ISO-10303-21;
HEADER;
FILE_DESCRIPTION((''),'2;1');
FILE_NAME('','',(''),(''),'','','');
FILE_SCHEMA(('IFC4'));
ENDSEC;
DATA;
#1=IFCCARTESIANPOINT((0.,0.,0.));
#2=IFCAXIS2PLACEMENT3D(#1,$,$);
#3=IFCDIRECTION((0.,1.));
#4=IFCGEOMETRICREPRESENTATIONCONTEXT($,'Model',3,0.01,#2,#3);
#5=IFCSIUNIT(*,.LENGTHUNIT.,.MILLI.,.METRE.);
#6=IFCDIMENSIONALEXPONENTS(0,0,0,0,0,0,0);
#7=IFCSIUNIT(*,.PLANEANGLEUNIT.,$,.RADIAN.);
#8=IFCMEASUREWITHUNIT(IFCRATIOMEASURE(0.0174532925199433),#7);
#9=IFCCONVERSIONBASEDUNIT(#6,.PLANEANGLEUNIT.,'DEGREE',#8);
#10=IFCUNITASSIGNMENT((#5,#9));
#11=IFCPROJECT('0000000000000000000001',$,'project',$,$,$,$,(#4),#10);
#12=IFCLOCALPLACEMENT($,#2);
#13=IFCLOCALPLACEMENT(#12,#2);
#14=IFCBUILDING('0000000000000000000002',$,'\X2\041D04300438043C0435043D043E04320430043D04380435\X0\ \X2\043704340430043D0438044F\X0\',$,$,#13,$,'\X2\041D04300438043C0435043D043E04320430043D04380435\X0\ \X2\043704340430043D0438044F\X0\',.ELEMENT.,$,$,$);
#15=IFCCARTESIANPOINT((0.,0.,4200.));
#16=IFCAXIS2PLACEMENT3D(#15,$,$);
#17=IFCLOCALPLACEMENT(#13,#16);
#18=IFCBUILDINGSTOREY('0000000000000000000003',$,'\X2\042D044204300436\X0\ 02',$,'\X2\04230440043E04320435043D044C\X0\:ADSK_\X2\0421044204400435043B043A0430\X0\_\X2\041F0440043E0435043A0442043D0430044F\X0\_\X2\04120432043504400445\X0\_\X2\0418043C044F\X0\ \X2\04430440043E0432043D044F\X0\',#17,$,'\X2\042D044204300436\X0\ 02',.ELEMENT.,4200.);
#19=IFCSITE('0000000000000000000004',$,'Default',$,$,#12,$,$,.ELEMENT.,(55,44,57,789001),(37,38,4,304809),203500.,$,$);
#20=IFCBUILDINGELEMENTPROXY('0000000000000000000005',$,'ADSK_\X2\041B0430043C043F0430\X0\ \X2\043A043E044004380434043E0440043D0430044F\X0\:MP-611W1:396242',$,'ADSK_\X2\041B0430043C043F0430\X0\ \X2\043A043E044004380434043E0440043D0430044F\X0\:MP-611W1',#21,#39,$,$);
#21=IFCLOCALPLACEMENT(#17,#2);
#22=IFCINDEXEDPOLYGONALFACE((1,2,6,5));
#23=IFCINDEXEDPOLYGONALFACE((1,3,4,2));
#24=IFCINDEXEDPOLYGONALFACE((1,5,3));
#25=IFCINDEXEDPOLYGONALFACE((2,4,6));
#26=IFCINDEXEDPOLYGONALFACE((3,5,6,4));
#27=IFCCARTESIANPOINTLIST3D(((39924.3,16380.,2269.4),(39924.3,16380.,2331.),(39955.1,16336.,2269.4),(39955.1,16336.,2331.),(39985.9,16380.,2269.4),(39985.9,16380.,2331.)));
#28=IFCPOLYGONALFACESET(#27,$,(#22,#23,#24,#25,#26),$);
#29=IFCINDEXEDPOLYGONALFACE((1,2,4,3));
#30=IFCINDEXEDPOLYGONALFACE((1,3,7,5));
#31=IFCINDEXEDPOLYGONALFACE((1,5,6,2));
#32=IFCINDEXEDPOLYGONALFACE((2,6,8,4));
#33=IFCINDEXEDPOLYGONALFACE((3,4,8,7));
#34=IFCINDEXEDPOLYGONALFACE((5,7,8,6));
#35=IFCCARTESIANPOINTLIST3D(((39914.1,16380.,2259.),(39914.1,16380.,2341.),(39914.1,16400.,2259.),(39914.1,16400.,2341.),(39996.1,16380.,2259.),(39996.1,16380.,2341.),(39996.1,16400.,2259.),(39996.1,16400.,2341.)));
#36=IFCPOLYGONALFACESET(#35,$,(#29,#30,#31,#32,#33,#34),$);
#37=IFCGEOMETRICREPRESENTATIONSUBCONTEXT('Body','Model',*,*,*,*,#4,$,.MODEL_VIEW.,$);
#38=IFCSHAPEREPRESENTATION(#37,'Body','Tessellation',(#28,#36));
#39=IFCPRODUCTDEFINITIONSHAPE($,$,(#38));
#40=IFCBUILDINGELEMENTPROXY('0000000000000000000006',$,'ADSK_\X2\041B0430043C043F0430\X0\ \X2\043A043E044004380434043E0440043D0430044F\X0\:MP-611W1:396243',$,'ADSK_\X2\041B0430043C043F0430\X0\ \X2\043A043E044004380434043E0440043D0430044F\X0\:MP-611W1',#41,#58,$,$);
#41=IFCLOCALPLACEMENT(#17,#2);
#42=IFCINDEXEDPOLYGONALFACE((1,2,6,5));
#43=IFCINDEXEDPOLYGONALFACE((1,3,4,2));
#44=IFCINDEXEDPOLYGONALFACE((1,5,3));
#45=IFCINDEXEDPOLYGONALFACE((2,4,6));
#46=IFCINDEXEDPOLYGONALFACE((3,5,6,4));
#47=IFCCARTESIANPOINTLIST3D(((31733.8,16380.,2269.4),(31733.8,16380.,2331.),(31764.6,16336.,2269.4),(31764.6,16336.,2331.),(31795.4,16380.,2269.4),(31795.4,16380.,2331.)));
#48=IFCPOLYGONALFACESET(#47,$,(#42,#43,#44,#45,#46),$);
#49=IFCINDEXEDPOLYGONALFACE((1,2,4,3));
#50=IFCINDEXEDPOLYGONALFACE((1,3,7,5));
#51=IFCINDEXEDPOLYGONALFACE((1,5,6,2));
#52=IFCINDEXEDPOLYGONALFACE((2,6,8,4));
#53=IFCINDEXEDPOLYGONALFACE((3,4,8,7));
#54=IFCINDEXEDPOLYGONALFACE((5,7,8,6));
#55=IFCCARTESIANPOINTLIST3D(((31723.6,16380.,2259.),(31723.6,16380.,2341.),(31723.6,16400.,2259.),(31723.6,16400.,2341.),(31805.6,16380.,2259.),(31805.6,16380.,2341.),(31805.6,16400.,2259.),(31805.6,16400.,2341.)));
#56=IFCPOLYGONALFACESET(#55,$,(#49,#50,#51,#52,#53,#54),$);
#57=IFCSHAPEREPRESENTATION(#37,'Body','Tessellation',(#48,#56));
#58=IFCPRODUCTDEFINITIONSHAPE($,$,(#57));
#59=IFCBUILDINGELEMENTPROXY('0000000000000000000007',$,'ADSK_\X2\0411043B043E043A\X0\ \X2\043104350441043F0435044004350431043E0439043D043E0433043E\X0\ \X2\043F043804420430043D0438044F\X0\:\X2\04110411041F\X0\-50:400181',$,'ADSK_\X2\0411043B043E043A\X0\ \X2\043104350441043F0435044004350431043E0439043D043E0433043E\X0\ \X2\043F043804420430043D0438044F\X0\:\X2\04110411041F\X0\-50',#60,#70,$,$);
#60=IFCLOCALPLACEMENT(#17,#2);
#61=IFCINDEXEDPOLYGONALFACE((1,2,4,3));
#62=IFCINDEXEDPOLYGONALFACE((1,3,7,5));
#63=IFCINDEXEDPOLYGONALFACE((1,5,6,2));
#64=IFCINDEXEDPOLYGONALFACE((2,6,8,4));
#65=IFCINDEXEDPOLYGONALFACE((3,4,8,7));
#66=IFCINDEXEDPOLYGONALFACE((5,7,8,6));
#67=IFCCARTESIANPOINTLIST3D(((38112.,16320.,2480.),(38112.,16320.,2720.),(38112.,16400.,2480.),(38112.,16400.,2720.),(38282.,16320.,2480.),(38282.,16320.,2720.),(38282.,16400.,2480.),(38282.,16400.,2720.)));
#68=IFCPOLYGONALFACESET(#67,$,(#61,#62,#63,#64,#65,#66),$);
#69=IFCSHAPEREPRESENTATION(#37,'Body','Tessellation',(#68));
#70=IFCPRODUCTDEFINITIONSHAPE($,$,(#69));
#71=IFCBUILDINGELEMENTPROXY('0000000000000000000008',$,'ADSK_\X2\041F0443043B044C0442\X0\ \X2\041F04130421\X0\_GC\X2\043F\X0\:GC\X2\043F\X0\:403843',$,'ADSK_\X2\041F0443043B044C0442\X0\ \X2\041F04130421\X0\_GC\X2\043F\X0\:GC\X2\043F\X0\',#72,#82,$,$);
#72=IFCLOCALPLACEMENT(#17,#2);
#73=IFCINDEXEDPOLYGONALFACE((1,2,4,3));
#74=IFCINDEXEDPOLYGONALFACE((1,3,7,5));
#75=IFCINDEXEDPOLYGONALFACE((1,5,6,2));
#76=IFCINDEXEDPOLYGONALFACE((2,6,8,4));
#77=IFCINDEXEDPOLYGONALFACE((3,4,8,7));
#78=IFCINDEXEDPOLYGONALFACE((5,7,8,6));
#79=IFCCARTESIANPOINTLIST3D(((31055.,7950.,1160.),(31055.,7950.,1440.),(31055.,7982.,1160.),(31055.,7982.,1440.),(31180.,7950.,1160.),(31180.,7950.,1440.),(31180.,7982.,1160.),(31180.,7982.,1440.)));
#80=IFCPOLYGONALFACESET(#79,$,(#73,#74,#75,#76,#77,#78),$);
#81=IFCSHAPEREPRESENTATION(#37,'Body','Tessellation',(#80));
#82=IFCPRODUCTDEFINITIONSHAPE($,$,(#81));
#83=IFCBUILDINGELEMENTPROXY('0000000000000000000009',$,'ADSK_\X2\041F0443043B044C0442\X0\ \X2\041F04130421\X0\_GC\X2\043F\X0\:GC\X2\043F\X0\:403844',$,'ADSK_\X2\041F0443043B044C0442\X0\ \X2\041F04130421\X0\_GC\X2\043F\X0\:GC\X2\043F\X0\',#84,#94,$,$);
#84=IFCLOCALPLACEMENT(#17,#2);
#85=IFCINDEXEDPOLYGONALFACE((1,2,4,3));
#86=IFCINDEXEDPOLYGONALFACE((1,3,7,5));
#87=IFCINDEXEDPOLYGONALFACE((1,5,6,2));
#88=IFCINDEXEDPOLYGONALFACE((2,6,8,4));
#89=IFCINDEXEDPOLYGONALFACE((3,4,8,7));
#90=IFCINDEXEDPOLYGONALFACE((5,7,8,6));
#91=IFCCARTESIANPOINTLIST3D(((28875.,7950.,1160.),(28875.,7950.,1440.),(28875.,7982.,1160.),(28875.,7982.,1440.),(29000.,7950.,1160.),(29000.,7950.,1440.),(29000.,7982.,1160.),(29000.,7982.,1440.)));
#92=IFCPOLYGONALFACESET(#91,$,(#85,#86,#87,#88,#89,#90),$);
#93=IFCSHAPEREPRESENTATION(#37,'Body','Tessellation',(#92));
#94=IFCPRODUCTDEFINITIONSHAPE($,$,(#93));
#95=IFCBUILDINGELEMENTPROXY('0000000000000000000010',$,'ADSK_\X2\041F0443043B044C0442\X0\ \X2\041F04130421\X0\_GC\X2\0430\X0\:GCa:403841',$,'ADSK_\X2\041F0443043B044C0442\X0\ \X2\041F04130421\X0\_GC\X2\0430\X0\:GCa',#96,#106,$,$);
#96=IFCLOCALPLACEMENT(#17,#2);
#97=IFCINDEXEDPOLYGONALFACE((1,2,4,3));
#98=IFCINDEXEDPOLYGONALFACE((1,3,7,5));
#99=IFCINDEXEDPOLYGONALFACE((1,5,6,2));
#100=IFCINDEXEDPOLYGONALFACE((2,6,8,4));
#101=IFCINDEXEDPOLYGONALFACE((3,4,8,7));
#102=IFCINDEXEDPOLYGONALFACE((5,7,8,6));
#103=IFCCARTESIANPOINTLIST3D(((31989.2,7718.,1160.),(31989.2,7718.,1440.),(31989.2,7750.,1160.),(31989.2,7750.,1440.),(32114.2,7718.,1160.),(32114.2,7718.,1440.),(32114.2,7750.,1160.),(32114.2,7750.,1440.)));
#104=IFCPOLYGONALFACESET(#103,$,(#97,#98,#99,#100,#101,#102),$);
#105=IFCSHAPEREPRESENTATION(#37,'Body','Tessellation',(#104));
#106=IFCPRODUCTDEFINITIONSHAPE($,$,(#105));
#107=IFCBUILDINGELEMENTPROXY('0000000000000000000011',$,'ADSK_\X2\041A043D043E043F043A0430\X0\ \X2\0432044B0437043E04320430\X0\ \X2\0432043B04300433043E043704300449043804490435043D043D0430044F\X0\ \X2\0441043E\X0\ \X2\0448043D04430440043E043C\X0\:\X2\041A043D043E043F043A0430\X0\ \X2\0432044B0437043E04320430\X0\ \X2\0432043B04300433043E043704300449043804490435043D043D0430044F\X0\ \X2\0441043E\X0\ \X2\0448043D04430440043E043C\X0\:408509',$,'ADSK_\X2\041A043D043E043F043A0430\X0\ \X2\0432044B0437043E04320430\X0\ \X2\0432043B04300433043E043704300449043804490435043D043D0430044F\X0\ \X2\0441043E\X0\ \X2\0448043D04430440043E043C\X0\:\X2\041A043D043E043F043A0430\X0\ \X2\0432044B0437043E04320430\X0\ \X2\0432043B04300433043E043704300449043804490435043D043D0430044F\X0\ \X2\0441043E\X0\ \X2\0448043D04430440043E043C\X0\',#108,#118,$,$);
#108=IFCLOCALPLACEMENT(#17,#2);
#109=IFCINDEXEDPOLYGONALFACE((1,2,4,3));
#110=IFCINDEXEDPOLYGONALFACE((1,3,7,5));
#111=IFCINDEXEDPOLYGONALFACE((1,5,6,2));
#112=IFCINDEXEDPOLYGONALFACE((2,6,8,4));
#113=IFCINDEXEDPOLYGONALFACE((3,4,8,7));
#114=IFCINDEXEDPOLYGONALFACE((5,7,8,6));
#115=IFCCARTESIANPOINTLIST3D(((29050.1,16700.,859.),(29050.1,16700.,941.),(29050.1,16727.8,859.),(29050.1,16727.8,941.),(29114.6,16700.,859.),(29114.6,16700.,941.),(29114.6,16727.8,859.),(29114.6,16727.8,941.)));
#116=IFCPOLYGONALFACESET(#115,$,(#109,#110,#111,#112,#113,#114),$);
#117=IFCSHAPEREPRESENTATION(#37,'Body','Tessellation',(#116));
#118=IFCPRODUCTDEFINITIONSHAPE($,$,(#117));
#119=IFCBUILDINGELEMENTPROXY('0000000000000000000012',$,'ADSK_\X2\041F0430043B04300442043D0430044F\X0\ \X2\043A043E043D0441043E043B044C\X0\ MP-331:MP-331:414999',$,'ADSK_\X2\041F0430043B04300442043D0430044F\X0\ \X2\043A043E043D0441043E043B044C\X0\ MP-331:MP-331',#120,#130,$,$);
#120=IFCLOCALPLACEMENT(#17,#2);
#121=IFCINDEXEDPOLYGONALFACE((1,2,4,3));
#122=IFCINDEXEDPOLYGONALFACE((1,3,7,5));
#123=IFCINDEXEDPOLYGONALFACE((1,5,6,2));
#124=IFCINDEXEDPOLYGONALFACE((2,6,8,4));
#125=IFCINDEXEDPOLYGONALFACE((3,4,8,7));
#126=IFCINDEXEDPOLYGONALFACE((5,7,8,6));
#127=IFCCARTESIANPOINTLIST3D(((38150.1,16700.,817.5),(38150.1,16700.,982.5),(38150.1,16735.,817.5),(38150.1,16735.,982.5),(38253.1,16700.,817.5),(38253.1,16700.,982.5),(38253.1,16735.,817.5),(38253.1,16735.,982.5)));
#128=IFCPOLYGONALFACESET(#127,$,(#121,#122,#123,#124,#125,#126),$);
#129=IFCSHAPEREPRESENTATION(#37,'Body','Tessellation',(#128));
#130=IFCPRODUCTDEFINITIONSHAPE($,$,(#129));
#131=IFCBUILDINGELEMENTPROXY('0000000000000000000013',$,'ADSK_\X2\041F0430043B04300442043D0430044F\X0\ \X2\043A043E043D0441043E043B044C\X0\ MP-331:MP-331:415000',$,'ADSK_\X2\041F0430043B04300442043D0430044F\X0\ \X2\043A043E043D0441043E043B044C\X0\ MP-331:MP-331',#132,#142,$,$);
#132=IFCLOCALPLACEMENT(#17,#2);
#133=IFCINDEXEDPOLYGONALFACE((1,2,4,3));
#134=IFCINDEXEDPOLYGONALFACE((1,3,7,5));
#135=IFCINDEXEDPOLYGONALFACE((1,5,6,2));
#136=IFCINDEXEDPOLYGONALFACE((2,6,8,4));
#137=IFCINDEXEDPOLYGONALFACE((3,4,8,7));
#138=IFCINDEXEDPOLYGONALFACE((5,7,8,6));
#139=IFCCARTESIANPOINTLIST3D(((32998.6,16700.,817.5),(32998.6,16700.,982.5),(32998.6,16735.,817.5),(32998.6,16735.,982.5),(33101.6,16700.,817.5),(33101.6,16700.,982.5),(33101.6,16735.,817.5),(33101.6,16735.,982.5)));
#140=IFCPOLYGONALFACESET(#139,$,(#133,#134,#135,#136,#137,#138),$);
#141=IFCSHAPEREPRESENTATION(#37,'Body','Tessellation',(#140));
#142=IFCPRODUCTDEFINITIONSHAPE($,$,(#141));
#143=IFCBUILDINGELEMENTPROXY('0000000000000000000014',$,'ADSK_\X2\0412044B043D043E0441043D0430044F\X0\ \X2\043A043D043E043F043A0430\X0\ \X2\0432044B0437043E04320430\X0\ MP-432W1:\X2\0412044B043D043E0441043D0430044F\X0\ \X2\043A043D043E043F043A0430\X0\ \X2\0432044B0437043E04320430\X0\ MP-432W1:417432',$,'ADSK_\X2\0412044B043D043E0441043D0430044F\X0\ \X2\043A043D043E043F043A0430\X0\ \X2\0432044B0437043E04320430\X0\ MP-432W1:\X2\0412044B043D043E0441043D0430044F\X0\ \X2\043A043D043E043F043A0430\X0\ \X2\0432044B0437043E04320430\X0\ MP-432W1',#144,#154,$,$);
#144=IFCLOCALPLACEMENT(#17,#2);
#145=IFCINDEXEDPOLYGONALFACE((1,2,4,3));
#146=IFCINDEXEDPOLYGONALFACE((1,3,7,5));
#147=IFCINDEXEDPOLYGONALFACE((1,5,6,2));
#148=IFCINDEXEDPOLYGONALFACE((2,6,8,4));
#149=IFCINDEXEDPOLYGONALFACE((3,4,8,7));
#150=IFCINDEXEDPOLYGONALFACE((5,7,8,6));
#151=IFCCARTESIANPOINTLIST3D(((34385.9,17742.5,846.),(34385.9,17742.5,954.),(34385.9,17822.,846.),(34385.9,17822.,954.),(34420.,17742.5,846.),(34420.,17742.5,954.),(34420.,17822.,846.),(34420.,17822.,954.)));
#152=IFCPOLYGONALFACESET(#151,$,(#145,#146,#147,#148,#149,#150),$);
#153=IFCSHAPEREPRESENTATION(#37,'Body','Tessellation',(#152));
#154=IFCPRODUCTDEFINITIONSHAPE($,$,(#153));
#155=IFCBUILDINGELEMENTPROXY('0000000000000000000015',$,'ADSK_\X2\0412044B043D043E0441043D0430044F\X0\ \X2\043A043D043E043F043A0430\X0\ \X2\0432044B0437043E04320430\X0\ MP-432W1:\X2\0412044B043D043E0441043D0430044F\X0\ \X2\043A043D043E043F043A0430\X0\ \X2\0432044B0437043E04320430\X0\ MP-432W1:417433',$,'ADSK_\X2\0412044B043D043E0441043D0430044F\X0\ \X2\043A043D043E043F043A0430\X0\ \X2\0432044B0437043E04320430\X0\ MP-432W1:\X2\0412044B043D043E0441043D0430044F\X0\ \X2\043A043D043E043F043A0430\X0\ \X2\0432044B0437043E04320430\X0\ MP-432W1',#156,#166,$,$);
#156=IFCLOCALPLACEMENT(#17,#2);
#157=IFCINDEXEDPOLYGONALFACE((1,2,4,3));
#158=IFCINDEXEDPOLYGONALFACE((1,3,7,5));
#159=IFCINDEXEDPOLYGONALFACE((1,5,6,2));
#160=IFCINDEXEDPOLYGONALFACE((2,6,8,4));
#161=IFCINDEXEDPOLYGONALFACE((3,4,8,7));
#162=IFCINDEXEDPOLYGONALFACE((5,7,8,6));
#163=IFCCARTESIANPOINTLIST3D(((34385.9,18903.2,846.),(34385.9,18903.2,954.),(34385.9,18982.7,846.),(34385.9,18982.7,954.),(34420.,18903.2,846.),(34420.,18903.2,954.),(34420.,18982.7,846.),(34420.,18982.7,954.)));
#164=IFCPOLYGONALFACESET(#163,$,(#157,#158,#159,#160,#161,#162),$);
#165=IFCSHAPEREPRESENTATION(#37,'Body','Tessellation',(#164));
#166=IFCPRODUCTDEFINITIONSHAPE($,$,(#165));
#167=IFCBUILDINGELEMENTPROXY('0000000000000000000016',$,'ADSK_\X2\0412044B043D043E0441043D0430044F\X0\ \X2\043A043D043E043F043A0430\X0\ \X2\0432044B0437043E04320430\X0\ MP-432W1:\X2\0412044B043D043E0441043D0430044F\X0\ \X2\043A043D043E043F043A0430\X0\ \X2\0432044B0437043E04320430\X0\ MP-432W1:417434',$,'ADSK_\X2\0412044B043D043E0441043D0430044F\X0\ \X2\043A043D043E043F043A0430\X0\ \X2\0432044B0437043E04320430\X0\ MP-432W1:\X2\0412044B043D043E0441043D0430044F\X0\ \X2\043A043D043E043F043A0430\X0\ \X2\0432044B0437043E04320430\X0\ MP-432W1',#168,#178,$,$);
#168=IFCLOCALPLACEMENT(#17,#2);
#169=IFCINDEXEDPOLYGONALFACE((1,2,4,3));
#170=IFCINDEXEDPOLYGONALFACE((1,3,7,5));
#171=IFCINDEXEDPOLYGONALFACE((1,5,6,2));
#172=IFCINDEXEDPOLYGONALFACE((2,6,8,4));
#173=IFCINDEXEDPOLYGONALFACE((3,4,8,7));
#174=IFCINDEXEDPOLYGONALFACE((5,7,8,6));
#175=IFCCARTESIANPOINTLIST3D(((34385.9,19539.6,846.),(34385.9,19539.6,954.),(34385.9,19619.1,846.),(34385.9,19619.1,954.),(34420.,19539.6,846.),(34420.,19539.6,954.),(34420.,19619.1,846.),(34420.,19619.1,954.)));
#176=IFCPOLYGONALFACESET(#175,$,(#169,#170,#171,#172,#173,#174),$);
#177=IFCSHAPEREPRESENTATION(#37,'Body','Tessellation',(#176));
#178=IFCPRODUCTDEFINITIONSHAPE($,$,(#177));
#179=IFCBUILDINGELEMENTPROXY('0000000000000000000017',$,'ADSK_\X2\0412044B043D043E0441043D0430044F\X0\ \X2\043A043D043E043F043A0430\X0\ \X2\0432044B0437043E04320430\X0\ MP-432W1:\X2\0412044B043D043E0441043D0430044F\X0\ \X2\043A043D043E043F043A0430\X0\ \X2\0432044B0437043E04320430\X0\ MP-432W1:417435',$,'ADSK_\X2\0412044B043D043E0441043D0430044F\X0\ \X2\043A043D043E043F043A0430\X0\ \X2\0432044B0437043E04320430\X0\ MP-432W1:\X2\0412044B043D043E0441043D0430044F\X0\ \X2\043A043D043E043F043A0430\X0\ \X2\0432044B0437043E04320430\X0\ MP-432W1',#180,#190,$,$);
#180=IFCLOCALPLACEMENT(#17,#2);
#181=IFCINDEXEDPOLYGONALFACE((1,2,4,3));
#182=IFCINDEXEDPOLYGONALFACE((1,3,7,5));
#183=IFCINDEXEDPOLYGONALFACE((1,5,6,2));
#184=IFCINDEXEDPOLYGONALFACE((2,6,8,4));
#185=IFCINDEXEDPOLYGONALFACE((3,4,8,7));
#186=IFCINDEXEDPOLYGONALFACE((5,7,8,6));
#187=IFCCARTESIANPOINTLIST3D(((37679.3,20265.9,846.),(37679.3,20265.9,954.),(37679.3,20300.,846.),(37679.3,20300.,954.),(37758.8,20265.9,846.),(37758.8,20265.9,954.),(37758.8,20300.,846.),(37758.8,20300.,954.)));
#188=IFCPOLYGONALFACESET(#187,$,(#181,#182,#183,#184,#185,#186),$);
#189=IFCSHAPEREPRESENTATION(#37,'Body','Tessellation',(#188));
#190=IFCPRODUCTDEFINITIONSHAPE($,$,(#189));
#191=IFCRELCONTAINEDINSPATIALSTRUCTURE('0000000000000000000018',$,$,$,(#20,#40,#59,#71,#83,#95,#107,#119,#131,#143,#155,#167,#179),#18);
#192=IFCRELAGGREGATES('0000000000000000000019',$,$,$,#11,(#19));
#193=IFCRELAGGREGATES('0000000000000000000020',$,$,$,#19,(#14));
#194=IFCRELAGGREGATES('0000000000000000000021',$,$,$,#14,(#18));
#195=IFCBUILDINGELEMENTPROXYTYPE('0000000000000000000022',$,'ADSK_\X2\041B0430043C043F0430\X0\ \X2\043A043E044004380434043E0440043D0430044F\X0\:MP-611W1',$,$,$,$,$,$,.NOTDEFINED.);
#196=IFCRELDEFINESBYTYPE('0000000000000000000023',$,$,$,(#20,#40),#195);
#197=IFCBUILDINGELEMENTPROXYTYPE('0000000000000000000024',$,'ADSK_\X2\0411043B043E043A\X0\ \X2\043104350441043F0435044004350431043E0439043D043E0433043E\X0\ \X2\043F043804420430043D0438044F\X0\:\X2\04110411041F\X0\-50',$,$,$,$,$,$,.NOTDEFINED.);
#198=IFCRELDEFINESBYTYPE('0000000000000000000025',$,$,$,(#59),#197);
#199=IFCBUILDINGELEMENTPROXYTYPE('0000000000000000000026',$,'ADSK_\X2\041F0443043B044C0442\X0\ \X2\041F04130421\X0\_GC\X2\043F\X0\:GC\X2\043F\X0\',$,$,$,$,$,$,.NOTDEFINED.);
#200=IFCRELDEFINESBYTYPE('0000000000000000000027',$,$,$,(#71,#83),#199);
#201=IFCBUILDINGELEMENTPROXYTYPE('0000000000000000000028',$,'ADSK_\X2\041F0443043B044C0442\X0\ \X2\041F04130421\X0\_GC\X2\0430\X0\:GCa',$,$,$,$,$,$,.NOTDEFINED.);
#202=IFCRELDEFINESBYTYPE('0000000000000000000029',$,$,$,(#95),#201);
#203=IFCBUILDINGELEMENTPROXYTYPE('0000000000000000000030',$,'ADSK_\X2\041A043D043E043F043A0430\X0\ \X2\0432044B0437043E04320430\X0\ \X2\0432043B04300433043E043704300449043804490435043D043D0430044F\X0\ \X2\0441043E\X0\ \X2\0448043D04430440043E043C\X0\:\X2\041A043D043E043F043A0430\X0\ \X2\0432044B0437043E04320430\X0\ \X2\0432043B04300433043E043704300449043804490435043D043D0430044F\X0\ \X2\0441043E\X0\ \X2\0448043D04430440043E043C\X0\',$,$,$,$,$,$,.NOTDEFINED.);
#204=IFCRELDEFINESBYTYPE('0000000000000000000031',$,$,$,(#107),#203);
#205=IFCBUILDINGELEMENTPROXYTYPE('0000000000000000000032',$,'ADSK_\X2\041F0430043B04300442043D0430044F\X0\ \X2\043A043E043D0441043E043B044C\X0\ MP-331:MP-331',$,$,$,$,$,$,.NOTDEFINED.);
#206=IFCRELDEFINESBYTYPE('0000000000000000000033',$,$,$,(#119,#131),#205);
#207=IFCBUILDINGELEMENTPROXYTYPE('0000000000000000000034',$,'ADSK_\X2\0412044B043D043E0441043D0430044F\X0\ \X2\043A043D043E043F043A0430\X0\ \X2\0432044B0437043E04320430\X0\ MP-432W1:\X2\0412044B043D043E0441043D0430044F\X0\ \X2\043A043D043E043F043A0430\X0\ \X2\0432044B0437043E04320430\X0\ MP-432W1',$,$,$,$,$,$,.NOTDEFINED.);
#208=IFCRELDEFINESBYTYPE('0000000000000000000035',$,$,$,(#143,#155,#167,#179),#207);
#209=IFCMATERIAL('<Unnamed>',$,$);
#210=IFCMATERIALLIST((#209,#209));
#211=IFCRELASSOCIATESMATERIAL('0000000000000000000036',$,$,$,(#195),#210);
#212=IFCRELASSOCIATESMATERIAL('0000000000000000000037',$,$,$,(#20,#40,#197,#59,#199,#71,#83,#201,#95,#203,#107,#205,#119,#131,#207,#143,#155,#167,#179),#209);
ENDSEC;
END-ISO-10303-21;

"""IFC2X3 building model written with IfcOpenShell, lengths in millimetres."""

from ifc_helpers import new_model, entity, si_unit, converted_unit, direction, frame, origin, origin_2d_with_axis, place, context, subcontext, project, spatial, polyline, rectangle, outline, extrude, source, transform, mapped, material, material_list, type_object, type_shapes, element, save


model = new_model("IFC2X3")

# Units and contexts
model_context = context("Model", 3, precision=0.01, world=origin(), true_north=direction((0.0, 1.0)))
body_context = subcontext(model_context, "Body", "Model", "MODEL_VIEW")
ifc_project = project(units=[si_unit("LENGTHUNIT", "METRE", prefix="MILLI"), converted_unit("PLANEANGLEUNIT", "DEGREE", entity("IfcRatioMeasure", 0.0174532925199433), si_unit("PLANEANGLEUNIT", "RADIAN"), dimensions=[0, 0, 0, 0, 0, 0, 0])], contexts=[model_context])

# Site, building, storey
site_placement = place(None, origin())
site = spatial("IfcSite", under=ifc_project, at=site_placement, Name="Default", CompositionType="ELEMENT", RefLatitude=(55, 44, 57, 789001), RefLongitude=(37, 38, 4, 304809), RefElevation=203500.0)
building_placement = place(site_placement, origin())
building = spatial("IfcBuilding", under=site, at=building_placement, Name="Наименование здания", LongName="Наименование здания", CompositionType="ELEMENT")
storey_placement = place(building_placement, frame((0.0, 0.0, 4200.0)))
storey = spatial("IfcBuildingStorey", under=building, at=storey_placement, Name="Этаж 02", ObjectType="Уровень:ADSK_Стрелка_Проектная_Вверх_Имя уровня", LongName="Этаж 02", CompositionType="ELEMENT", Elevation=4200.0)

# Building element proxies
ifc_material_1 = material(Name="<Unnamed>")
ifc_material_list_1 = material_list([ifc_material_1, ifc_material_1])
building_element_proxy_type_1 = type_object("IfcBuildingElementProxyType", Name="ADSK_Лампа коридорная:MP-611W1", PredefinedType="NOTDEFINED", material=ifc_material_list_1)
shared_shape_1 = source(origin(), body_context, "Body", "SweptSolid", [
    extrude(outline(polyline([(-30.8, -14.7), (30.8, -14.7), (0.0, 29.3), (-30.8, -14.7)])), frame((0.0, -2.7, -30.6), z_axis=(0.0, 0.0, 1.0), x_axis=(-1.0, 0.0, 0.0)), (0.0, 0.0, 1.0), 61.6),
    extrude(rectangle(XDim=82.0, YDim=20.0, at=origin_2d_with_axis()), frame((0.0, 22.0, -41.0), z_axis=(0.0, 0.0, 1.0), x_axis=(-1.0, 0.0, 0.0)), (0.0, 0.0, 1.0), 82.0),
])
type_shapes(building_element_proxy_type_1, [shared_shape_1])
for number, where, name in (
    (1, (39955.1, 16368.0, 2300.0), "ADSK_Лампа коридорная:MP-611W1:396242"),
    (2, (31764.6, 16368.0, 2300.0), "ADSK_Лампа коридорная:MP-611W1:396243"),
):
    element("IfcBuildingElementProxy", number, at=place(storey_placement, frame(where)), inside=storey, type_object=building_element_proxy_type_1, material=ifc_material_1, Name=name, ObjectType="ADSK_Лампа коридорная:MP-611W1", context=body_context, shape_type="MappedRepresentation", body=[
        mapped(shared_shape_1, transform((0.0, 0.0, 0.0), scale=1.0)),
    ])
building_element_proxy_type_2 = type_object("IfcBuildingElementProxyType", Name="ADSK_Блок бесперебойного питания:ББП-50", PredefinedType="NOTDEFINED", material=ifc_material_1)
shared_shape_2 = source(origin(), body_context, "Body", "SweptSolid", [
    extrude(rectangle(XDim=170.0, YDim=80.0, at=origin_2d_with_axis()), frame((0.0, -8.0, -120.0), z_axis=(0.0, 0.0, 1.0), x_axis=(-1.0, 0.0, 0.0)), (0.0, 0.0, 1.0), 240.0),
])
type_shapes(building_element_proxy_type_2, [shared_shape_2])
proxy_1_placement = place(storey_placement, frame((38197.0, 16368.0, 2600.0)))
element("IfcBuildingElementProxy", 3, at=proxy_1_placement, inside=storey, type_object=building_element_proxy_type_2, material=ifc_material_1, Name="ADSK_Блок бесперебойного питания:ББП-50:400181", ObjectType="ADSK_Блок бесперебойного питания:ББП-50", context=body_context, shape_type="MappedRepresentation", body=[
    mapped(shared_shape_2, transform((0.0, 0.0, 0.0), scale=1.0)),
])
building_element_proxy_type_3 = type_object("IfcBuildingElementProxyType", Name="ADSK_Пульт ПГС_GCп:GCп", PredefinedType="NOTDEFINED", material=ifc_material_1)
shared_shape_3 = source(origin(), body_context, "Body", "SweptSolid", [
    extrude(rectangle(XDim=125.0, YDim=32.0, at=origin_2d_with_axis()), frame((0.0, 16.0, -140.0), z_axis=(0.0, 0.0, 1.0), x_axis=(-1.0, 0.0, 0.0)), (0.0, 0.0, 1.0), 280.0),
])
type_shapes(building_element_proxy_type_3, [shared_shape_3])
for number, where, z_axis, x_axis, name in (
    (4, (31117.5, 7982.0, 1300.0), (0.0, 0.0, 1.0), (-1.0, 0.0, 0.0), "ADSK_Пульт ПГС_GCп:GCп:403843"),
    (5, (28937.5, 7982.0, 1300.0), (0.0, 0.0, 1.0), (-1.0, 0.0, 0.0), "ADSK_Пульт ПГС_GCп:GCп:403844"),
):
    element("IfcBuildingElementProxy", number, at=place(storey_placement, frame(where, z_axis=z_axis, x_axis=x_axis)), inside=storey, type_object=building_element_proxy_type_3, material=ifc_material_1, Name=name, ObjectType="ADSK_Пульт ПГС_GCп:GCп", context=body_context, shape_type="MappedRepresentation", body=[
        mapped(shared_shape_3, transform((0.0, 0.0, 0.0), scale=1.0)),
    ])
building_element_proxy_type_4 = type_object("IfcBuildingElementProxyType", Name="ADSK_Пульт ПГС_GCа:GCa", PredefinedType="NOTDEFINED", material=ifc_material_1)
shared_shape_4 = source(origin(), body_context, "Body", "SweptSolid", [
    extrude(rectangle(XDim=125.0, YDim=32.0, at=origin_2d_with_axis()), frame((0.0, 16.0, -140.0), z_axis=(0.0, 0.0, 1.0), x_axis=(-1.0, 0.0, 0.0)), (0.0, 0.0, 1.0), 280.0),
])
type_shapes(building_element_proxy_type_4, [shared_shape_4])
proxy_2_placement = place(storey_placement, frame((32051.7, 7718.0, 1300.0)))
element("IfcBuildingElementProxy", 6, at=proxy_2_placement, inside=storey, type_object=building_element_proxy_type_4, material=ifc_material_1, Name="ADSK_Пульт ПГС_GCа:GCa:403841", ObjectType="ADSK_Пульт ПГС_GCа:GCa", context=body_context, shape_type="MappedRepresentation", body=[
    mapped(shared_shape_4, transform((0.0, 0.0, 0.0), scale=1.0)),
])
building_element_proxy_type_5 = type_object("IfcBuildingElementProxyType", Name="ADSK_Кнопка вызова влагозащищенная со шнуром:Кнопка вызова влагозащищенная со шнуром", PredefinedType="NOTDEFINED", material=ifc_material_1)
shared_shape_5 = source(origin(), body_context, "Body", "SweptSolid", [
    extrude(rectangle(XDim=64.5, YDim=27.8, at=origin_2d_with_axis()), frame((32.2, 13.9, 0.0), z_axis=(0.0, 0.0, 1.0), x_axis=(-1.0, 0.0, 0.0)), (0.0, 0.0, 1.0), 82.0),
])
type_shapes(building_element_proxy_type_5, [shared_shape_5])
proxy_3_placement = place(storey_placement, frame((29114.6, 16727.8, 859.0), z_axis=(0.0, 0.0, 1.0), x_axis=(-1.0, 0.0, 0.0)))
element("IfcBuildingElementProxy", 7, at=proxy_3_placement, inside=storey, type_object=building_element_proxy_type_5, material=ifc_material_1, Name="ADSK_Кнопка вызова влагозащищенная со шнуром:Кнопка вызова влагозащищенная со шнуром:408509", ObjectType="ADSK_Кнопка вызова влагозащищенная со шнуром:Кнопка вызова влагозащищенная со шнуром", context=body_context, shape_type="MappedRepresentation", body=[
    mapped(shared_shape_5, transform((0.0, 0.0, 0.0), scale=1.0)),
])
building_element_proxy_type_6 = type_object("IfcBuildingElementProxyType", Name="ADSK_Палатная консоль MP-331:MP-331", PredefinedType="NOTDEFINED", material=ifc_material_1)
shared_shape_6 = source(origin(), body_context, "Body", "SweptSolid", [
    extrude(rectangle(XDim=103.0, YDim=35.0, at=origin_2d_with_axis()), frame((0.0, 14.5, -82.5), z_axis=(0.0, 0.0, 1.0), x_axis=(-1.0, 0.0, 0.0)), (0.0, 0.0, 1.0), 165.0),
])
type_shapes(building_element_proxy_type_6, [shared_shape_6])
for number, where, z_axis, x_axis, name in (
    (8, (38201.6, 16732.0, 900.0), (0.0, 0.0, 1.0), (-1.0, 0.0, 0.0), "ADSK_Палатная консоль MP-331:MP-331:414999"),
    (9, (33050.1, 16732.0, 900.0), (0.0, 0.0, 1.0), (-1.0, 0.0, 0.0), "ADSK_Палатная консоль MP-331:MP-331:415000"),
):
    element("IfcBuildingElementProxy", number, at=place(storey_placement, frame(where, z_axis=z_axis, x_axis=x_axis)), inside=storey, type_object=building_element_proxy_type_6, material=ifc_material_1, Name=name, ObjectType="ADSK_Палатная консоль MP-331:MP-331", context=body_context, shape_type="MappedRepresentation", body=[
        mapped(shared_shape_6, transform((0.0, 0.0, 0.0), scale=1.0)),
    ])
building_element_proxy_type_7 = type_object("IfcBuildingElementProxyType", Name="ADSK_Выносная кнопка вызова MP-432W1:Выносная кнопка вызова MP-432W1", PredefinedType="NOTDEFINED", material=ifc_material_1)
shared_shape_7 = source(origin(), body_context, "Body", "SweptSolid", [
    extrude(rectangle(XDim=79.5, YDim=34.1, at=origin_2d_with_axis()), frame((0.0, 15.0, -54.0), z_axis=(0.0, 0.0, 1.0), x_axis=(-1.0, 0.0, 0.0)), (0.0, 0.0, 1.0), 108.0),
])
type_shapes(building_element_proxy_type_7, [shared_shape_7])
for number, where, z_axis, x_axis, name in (
    (10, (34388.0, 17782.3, 900.0), (0.0, 0.0, 1.0), (0.0, -1.0, 0.0), "ADSK_Выносная кнопка вызова MP-432W1:Выносная кнопка вызова MP-432W1:417432"),
    (11, (34388.0, 18943.0, 900.0), (0.0, 0.0, 1.0), (0.0, -1.0, 0.0), "ADSK_Выносная кнопка вызова MP-432W1:Выносная кнопка вызова MP-432W1:417433"),
    (12, (34388.0, 19579.4, 900.0), (0.0, 0.0, 1.0), (0.0, -1.0, 0.0), "ADSK_Выносная кнопка вызова MP-432W1:Выносная кнопка вызова MP-432W1:417434"),
):
    element("IfcBuildingElementProxy", number, at=place(storey_placement, frame(where, z_axis=z_axis, x_axis=x_axis)), inside=storey, type_object=building_element_proxy_type_7, material=ifc_material_1, Name=name, ObjectType="ADSK_Выносная кнопка вызова MP-432W1:Выносная кнопка вызова MP-432W1", context=body_context, shape_type="MappedRepresentation", body=[
        mapped(shared_shape_7, transform((0.0, 0.0, 0.0), scale=1.0)),
    ])
for number, where, name in (
    (13, (37719.0, 20268.0, 900.0), "ADSK_Выносная кнопка вызова MP-432W1:Выносная кнопка вызова MP-432W1:417435"),
):
    element("IfcBuildingElementProxy", number, at=place(storey_placement, frame(where)), inside=storey, type_object=building_element_proxy_type_7, material=ifc_material_1, Name=name, ObjectType="ADSK_Выносная кнопка вызова MP-432W1:Выносная кнопка вызова MP-432W1", context=body_context, shape_type="MappedRepresentation", body=[
        mapped(shared_shape_7, transform((0.0, 0.0, 0.0), scale=1.0)),
    ])

save(model, "model.ifc")
